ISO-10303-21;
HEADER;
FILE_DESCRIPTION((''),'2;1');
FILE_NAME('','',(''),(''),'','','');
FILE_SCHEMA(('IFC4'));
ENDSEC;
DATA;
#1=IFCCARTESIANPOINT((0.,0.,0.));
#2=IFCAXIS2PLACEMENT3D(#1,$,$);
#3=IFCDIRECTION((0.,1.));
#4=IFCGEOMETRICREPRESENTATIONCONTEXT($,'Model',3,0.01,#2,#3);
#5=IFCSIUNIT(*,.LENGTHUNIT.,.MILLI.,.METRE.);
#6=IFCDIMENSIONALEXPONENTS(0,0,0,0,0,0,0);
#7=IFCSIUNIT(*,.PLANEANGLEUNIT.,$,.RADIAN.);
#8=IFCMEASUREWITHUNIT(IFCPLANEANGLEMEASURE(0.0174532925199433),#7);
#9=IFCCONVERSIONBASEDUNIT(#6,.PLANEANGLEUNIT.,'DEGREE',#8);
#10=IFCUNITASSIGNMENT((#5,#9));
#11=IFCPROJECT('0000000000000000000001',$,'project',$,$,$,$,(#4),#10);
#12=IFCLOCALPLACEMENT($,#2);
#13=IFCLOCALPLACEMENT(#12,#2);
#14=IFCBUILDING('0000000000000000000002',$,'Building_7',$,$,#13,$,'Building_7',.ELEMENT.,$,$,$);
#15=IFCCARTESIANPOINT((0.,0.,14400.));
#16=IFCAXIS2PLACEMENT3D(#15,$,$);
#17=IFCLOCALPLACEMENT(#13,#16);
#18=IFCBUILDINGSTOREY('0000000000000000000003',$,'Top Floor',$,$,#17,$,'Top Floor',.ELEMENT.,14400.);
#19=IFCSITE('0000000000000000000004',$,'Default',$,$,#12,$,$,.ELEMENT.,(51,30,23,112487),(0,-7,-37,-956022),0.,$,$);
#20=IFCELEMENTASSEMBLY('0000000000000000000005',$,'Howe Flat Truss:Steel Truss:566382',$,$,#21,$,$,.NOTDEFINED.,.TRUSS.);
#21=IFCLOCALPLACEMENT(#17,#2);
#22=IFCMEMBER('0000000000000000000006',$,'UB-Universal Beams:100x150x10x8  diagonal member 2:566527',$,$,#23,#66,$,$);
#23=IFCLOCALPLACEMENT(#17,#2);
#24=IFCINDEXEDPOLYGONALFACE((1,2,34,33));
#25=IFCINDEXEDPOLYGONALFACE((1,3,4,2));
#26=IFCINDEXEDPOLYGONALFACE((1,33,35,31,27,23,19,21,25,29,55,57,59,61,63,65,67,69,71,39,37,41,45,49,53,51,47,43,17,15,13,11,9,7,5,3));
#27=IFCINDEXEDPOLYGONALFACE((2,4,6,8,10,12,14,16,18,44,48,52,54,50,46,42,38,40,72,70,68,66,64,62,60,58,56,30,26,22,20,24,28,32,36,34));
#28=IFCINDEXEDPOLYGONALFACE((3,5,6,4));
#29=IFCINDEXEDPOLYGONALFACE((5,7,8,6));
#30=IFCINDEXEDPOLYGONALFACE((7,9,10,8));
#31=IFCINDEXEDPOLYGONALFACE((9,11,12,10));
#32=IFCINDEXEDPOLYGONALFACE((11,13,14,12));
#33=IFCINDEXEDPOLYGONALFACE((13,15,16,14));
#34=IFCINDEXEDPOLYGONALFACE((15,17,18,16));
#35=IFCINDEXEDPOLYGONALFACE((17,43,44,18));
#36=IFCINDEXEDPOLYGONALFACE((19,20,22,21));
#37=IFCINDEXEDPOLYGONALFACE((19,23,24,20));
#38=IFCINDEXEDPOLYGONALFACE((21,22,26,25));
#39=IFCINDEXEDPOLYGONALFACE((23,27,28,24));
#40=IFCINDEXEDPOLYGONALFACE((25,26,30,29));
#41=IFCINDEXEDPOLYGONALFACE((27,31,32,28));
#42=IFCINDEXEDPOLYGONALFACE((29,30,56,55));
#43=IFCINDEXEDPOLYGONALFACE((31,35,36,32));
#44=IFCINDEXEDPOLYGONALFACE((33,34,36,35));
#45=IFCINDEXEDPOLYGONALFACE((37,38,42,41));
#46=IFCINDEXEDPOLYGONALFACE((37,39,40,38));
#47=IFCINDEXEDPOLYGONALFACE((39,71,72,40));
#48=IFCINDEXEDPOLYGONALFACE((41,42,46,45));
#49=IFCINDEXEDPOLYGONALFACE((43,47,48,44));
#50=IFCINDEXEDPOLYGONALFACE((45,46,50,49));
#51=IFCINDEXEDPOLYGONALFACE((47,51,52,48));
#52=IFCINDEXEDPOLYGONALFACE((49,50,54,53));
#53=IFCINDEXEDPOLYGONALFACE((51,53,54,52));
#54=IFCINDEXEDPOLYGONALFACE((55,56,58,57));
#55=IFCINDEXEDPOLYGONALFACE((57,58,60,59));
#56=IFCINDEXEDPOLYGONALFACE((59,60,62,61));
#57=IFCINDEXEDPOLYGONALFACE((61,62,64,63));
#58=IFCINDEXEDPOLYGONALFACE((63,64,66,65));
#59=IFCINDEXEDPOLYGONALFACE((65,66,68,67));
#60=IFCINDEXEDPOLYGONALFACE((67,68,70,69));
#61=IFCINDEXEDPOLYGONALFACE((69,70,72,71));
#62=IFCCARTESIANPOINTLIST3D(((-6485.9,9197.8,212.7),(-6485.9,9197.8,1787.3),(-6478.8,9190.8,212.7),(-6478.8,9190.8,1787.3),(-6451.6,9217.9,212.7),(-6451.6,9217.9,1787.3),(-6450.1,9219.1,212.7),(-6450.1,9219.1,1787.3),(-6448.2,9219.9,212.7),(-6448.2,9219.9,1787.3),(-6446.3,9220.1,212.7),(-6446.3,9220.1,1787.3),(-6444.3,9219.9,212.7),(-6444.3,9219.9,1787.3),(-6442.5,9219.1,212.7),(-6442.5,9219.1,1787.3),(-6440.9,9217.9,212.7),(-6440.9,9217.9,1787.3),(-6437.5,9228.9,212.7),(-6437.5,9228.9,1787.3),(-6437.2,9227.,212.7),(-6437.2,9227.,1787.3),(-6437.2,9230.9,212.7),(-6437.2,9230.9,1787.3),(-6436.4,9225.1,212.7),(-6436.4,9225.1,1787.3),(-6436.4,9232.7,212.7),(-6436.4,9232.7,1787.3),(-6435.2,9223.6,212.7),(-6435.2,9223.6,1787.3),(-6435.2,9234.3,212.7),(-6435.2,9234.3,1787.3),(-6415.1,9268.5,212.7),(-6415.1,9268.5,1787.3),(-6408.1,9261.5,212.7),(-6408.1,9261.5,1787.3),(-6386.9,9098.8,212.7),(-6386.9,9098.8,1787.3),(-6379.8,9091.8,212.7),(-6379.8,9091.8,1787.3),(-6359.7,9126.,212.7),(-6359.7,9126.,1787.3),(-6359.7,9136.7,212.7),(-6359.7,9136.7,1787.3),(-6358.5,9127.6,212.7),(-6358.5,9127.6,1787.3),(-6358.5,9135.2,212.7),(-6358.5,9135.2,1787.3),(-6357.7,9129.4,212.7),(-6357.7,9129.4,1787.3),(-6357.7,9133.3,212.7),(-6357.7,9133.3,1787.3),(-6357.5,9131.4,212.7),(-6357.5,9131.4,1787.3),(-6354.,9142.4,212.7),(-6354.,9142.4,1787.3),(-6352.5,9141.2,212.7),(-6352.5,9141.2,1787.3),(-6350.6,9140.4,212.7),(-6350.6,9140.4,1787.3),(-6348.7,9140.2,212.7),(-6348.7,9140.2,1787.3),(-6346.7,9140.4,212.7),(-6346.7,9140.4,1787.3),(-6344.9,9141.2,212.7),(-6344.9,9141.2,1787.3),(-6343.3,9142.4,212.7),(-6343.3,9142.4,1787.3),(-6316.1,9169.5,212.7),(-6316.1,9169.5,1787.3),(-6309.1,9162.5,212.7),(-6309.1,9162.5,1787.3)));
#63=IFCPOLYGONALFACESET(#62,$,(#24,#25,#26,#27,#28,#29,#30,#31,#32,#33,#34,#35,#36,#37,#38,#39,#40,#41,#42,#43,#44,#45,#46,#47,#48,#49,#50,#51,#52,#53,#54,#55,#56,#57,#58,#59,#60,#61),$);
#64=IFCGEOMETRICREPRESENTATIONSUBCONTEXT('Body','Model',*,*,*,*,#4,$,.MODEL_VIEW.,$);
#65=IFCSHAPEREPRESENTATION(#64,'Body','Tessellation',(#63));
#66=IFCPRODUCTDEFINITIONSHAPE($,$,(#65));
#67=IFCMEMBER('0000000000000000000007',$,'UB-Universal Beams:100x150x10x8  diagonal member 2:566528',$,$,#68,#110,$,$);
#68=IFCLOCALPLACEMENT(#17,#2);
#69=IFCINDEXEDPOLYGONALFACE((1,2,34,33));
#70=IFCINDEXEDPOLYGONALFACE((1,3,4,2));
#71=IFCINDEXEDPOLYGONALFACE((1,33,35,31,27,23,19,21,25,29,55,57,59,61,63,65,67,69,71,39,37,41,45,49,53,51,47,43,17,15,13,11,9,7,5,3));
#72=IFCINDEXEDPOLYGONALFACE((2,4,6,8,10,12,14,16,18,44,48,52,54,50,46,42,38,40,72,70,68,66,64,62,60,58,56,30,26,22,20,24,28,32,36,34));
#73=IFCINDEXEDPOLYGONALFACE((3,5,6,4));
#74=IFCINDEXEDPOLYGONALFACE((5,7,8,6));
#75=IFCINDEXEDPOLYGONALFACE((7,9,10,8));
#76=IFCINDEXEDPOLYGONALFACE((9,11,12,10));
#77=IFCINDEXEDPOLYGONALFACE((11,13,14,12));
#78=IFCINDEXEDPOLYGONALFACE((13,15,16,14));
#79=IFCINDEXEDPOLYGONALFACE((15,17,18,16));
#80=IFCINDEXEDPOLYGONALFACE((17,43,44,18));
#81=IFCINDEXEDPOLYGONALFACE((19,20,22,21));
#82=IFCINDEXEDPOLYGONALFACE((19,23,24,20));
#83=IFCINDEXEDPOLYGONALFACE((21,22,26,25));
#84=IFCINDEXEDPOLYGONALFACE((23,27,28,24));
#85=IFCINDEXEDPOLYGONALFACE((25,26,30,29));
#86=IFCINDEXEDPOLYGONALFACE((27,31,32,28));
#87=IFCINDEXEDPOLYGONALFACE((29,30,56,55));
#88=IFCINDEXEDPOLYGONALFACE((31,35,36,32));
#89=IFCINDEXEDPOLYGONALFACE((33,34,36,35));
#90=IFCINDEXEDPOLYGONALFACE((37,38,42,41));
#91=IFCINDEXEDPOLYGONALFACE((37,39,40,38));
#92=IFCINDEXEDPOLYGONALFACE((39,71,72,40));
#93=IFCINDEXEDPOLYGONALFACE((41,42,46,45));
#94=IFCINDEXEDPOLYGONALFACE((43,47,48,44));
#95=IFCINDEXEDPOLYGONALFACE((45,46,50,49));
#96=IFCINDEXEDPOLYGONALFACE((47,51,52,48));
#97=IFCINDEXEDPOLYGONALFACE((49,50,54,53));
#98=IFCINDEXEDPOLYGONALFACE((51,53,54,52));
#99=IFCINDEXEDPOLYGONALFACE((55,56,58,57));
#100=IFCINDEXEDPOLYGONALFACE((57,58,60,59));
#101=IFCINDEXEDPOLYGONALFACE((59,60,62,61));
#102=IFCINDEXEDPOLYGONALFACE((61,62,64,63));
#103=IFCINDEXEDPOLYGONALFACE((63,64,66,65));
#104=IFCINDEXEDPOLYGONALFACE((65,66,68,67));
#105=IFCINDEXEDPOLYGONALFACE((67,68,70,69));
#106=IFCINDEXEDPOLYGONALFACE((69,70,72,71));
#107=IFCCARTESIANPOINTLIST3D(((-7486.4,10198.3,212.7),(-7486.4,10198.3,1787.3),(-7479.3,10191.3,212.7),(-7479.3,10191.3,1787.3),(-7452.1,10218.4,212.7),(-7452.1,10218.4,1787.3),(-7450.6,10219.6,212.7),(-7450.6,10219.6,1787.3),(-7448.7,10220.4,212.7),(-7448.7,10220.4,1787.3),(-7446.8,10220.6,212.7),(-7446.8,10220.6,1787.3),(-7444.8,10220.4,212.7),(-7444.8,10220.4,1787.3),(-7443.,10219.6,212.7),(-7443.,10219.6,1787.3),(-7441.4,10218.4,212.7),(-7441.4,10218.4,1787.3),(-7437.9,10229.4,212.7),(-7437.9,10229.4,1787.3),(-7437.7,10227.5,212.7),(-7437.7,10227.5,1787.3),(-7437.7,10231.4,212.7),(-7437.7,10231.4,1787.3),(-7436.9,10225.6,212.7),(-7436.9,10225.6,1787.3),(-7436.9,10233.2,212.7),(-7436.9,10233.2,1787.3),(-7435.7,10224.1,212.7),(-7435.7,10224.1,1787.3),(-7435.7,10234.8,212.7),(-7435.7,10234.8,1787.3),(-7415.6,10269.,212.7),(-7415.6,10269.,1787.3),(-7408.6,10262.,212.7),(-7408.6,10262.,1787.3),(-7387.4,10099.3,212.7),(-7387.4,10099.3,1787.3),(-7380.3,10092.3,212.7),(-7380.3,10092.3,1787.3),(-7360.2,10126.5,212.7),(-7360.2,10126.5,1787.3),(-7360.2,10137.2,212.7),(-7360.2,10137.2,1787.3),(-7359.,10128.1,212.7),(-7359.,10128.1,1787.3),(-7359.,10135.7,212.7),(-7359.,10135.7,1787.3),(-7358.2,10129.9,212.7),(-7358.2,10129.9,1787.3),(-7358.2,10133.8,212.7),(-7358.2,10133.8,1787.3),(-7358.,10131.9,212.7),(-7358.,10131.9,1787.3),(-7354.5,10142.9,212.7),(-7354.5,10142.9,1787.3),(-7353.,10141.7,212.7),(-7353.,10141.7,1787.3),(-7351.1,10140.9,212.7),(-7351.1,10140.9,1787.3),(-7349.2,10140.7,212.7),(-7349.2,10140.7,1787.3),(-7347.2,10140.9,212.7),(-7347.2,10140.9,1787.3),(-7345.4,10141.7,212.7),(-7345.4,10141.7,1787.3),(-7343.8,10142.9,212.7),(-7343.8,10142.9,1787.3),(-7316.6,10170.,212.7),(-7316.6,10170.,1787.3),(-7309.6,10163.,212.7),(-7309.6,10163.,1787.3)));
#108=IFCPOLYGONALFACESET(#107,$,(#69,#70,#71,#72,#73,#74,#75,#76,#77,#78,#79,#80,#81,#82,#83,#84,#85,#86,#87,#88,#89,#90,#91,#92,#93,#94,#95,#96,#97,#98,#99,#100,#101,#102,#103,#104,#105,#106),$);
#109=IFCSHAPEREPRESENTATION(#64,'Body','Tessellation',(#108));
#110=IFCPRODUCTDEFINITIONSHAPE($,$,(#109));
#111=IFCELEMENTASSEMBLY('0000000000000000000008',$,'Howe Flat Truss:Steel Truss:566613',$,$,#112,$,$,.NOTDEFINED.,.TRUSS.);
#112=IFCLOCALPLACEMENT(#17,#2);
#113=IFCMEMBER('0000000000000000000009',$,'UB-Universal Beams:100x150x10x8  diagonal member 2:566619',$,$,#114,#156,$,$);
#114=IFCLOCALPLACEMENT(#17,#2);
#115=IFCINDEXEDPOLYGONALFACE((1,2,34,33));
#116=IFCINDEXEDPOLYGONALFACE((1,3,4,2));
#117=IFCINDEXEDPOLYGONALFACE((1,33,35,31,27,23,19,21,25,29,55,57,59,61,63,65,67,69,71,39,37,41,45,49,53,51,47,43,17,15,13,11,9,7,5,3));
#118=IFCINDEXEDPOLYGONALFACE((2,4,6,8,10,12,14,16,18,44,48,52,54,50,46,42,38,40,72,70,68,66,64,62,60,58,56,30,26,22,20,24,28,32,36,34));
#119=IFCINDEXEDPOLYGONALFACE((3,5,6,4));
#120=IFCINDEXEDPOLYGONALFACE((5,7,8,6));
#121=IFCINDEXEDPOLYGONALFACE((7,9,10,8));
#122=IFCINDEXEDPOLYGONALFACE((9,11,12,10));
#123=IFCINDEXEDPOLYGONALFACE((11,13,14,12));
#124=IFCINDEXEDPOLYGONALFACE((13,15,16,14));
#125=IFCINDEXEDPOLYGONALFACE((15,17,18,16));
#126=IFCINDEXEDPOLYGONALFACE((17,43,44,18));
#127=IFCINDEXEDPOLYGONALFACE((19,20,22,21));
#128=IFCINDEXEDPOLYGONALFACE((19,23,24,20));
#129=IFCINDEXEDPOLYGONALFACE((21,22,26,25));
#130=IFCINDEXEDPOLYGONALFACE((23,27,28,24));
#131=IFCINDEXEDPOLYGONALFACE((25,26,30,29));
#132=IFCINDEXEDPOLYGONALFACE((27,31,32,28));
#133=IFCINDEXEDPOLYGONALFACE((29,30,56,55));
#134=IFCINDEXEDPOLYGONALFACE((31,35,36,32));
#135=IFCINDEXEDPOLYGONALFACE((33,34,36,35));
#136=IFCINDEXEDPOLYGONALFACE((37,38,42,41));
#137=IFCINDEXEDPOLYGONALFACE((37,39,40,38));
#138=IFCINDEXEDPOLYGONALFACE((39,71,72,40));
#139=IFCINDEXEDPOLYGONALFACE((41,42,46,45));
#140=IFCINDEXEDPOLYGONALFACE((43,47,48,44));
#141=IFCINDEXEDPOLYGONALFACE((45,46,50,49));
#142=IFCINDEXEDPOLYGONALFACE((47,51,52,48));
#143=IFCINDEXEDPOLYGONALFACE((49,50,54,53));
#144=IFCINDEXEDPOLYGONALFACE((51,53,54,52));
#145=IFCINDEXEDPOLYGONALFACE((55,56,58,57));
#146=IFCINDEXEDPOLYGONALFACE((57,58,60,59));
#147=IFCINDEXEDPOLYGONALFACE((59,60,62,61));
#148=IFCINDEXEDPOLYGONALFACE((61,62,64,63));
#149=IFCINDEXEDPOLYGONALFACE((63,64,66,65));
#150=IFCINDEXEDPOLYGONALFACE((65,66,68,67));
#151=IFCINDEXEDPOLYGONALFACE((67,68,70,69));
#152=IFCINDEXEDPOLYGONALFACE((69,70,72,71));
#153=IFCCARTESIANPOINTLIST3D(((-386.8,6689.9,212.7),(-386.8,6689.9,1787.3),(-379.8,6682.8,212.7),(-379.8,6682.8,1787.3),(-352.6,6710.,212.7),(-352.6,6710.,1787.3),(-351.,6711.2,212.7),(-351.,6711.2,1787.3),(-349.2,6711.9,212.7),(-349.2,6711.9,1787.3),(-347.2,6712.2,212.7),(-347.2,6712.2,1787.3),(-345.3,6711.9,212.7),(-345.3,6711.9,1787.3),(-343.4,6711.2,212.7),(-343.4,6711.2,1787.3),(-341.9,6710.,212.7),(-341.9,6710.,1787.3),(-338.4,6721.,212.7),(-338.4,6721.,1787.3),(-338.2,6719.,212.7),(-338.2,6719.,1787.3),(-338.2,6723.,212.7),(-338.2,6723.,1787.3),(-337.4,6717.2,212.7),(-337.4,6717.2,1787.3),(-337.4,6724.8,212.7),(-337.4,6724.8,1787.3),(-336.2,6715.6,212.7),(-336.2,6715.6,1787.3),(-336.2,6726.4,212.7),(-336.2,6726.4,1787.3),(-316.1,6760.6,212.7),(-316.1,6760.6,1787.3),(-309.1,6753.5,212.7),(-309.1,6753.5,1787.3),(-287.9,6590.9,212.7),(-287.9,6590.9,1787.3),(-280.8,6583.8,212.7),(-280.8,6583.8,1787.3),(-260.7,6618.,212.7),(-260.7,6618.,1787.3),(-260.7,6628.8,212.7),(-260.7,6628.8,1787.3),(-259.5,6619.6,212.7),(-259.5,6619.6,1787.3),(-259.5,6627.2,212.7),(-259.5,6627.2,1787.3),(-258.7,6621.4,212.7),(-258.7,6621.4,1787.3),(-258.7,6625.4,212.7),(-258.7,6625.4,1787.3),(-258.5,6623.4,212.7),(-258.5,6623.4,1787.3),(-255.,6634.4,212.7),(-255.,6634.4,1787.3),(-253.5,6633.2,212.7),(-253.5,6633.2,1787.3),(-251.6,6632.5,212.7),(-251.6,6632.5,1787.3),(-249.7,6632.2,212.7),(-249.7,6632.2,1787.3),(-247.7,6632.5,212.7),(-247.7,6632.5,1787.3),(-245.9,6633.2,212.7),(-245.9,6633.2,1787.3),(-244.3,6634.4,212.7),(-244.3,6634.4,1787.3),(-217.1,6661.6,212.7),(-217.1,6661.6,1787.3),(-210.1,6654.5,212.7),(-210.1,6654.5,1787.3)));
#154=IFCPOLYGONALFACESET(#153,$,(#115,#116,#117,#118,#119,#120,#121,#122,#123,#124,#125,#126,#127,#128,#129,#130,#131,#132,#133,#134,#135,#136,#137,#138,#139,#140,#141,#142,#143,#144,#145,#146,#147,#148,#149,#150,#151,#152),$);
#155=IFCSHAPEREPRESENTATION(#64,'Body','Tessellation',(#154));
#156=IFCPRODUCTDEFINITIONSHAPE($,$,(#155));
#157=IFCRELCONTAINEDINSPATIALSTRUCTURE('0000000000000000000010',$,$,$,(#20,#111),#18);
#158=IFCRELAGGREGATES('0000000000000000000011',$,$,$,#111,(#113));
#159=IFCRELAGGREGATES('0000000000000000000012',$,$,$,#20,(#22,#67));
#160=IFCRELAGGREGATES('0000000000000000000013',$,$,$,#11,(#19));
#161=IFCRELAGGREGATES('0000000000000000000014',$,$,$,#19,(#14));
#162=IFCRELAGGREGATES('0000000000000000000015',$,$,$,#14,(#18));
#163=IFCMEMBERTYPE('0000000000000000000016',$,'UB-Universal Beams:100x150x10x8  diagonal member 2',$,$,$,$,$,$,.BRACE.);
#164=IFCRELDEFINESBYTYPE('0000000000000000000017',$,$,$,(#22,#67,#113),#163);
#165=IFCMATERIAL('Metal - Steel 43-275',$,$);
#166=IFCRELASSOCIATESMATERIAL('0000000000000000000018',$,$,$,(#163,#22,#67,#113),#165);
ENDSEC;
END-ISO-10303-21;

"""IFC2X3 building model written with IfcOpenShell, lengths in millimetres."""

from ifc_helpers import new_model, entity, si_unit, converted_unit, direction, frame, frame_2d, origin, place, context, subcontext, project, spatial, polyline, circle_curve, parameter, trimmed, segment, composite_curve, outline, extrude, source, transform, mapped, material, type_object, type_shapes, element, aggregate, save


model = new_model("IFC2X3")

# Units and contexts
model_context = context("Model", 3, precision=0.01, world=origin(), true_north=direction((0.0, 1.0)))
body_context = subcontext(model_context, "Body", "Model", "MODEL_VIEW")
ifc_project = project(units=[si_unit("LENGTHUNIT", "METRE", prefix="MILLI"), converted_unit("PLANEANGLEUNIT", "DEGREE", entity("IfcPlaneAngleMeasure", 0.0174532925199433), si_unit("PLANEANGLEUNIT", "RADIAN"), dimensions=[0, 0, 0, 0, 0, 0, 0])], contexts=[model_context])

# Site, building, storey
site_placement = place(None, origin())
site = spatial("IfcSite", under=ifc_project, at=site_placement, Name="Default", CompositionType="ELEMENT", RefLatitude=(51, 30, 23, 112487), RefLongitude=(0, -7, -37, -956022), RefElevation=0.0)
building_placement = place(site_placement, origin())
building = spatial("IfcBuilding", under=site, at=building_placement, Name="Building_7", LongName="Building_7", CompositionType="ELEMENT")
storey_placement = place(building_placement, frame((0.0, 0.0, 14400.0)))
storey = spatial("IfcBuildingStorey", under=building, at=storey_placement, Name="Top Floor", LongName="Top Floor", CompositionType="ELEMENT", Elevation=14400.0)

# Shared definitions
ifc_material = material(Name="Metal - Steel 43-275")

# Shared definitions
member_type_1 = type_object("IfcMemberType", Name="UB-Universal Beams:100x150x10x8  diagonal member 2", PredefinedType="BRACE", material=ifc_material)
shared_shape_1 = source(origin(), body_context, "Body", "SweptSolid", [
    extrude(outline(composite_curve([segment(polyline([(-50.0, -65.0), (-50.0, -75.0)]), True, "CONTINUOUS"), segment(polyline([(-50.0, -75.0), (50.0, -75.0)]), True, "CONTINUOUS"), segment(polyline([(50.0, -75.0), (50.0, -65.0)]), True, "CONTINUOUS"), segment(polyline([(50.0, -65.0), (11.6, -65.0)]), True, "CONTINUOUS"), segment(trimmed(circle_curve(frame_2d((11.6, -57.4), x_axis=(1.0, 0.0)), 7.6), [parameter(180.0)], [parameter(270.0)], True, "PARAMETER"), False, "CONTINUOUS"), segment(polyline([(4.0, -57.4), (4.0, 57.4)]), True, "CONTINUOUS"), segment(trimmed(circle_curve(frame_2d((11.6, 57.4), x_axis=(1.0, 0.0)), 7.6), [parameter(90.0)], [parameter(180.0)], True, "PARAMETER"), False, "CONTINUOUS"), segment(polyline([(11.6, 65.0), (50.0, 65.0)]), True, "CONTINUOUS"), segment(polyline([(50.0, 65.0), (50.0, 75.0)]), True, "CONTINUOUS"), segment(polyline([(50.0, 75.0), (-50.0, 75.0)]), True, "CONTINUOUS"), segment(polyline([(-50.0, 75.0), (-50.0, 65.0)]), True, "CONTINUOUS"), segment(polyline([(-50.0, 65.0), (-11.6, 65.0)]), True, "CONTINUOUS"), segment(trimmed(circle_curve(frame_2d((-11.6, 57.4), x_axis=(1.0, 0.0)), 7.6), [parameter(360.0)], [parameter(90.0)], True, "PARAMETER"), False, "CONTINUOUS"), segment(polyline([(-4.0, 57.4), (-4.0, -57.4)]), True, "CONTINUOUS"), segment(trimmed(circle_curve(frame_2d((-11.6, -57.4), x_axis=(1.0, 0.0)), 7.6), [parameter(270.0)], [parameter(360.0)], True, "PARAMETER"), False, "CONTINUOUS"), segment(polyline([(-11.6, -65.0), (-50.0, -65.0)]), True, "CONTINUOUS")], self_intersect=False)), frame((-787.3, 0.0, 0.0), z_axis=(-1.0, 0.0, 0.0), x_axis=(0.0, -1.0, 0.0)), (0.0, 0.0, -1.0), 1574.6),
])
type_shapes(member_type_1, [shared_shape_1])

# Element assemblies, members
assembly_1_placement = place(storey_placement, origin())
assembly_1 = element("IfcElementAssembly", 1, at=assembly_1_placement, inside=storey, Name="Howe Flat Truss:Steel Truss:566382", AssemblyPlace="NOTDEFINED", PredefinedType="TRUSS")
member_1_placement = place(assembly_1_placement, frame((-6397.5, 9180.2, 1000.0), z_axis=(-0.707107, 0.707107, 0.0), x_axis=(0.0, 0.0, 1.0)))
member_1 = element("IfcMember", 2, at=member_1_placement, type_object=member_type_1, material=ifc_material, Name="UB-Universal Beams:100x150x10x8  diagonal member 2:566527", context=body_context, shape_type="MappedRepresentation", body=[
    mapped(shared_shape_1, transform((0.0, 0.0, 0.0), scale=1.0)),
])
member_2_placement = place(assembly_1_placement, frame((-7398.0, 10180.7, 1000.0), z_axis=(-0.707107, 0.707107, 0.0), x_axis=(0.0, 0.0, 1.0)))
member_2 = element("IfcMember", 3, at=member_2_placement, type_object=member_type_1, material=ifc_material, Name="UB-Universal Beams:100x150x10x8  diagonal member 2:566528", context=body_context, shape_type="MappedRepresentation", body=[
    mapped(shared_shape_1, transform((0.0, 0.0, 0.0), scale=1.0)),
])
assembly_2_placement = place(storey_placement, origin())
assembly_2 = element("IfcElementAssembly", 4, at=assembly_2_placement, inside=storey, Name="Howe Flat Truss:Steel Truss:566613", AssemblyPlace="NOTDEFINED", PredefinedType="TRUSS")
member_3_placement = place(assembly_2_placement, frame((-298.5, 6672.2, 1000.0), z_axis=(0.707107, -0.707107, 0.0), x_axis=(0.0, 0.0, 1.0)))
member_3 = element("IfcMember", 5, at=member_3_placement, type_object=member_type_1, material=ifc_material, Name="UB-Universal Beams:100x150x10x8  diagonal member 2:566619", context=body_context, shape_type="MappedRepresentation", body=[
    mapped(shared_shape_1, transform((0.0, 0.0, 0.0), scale=1.0)),
])

aggregate(assembly_2, [member_3])
aggregate(assembly_1, [member_1, member_2])

save(model, "model.ifc")
